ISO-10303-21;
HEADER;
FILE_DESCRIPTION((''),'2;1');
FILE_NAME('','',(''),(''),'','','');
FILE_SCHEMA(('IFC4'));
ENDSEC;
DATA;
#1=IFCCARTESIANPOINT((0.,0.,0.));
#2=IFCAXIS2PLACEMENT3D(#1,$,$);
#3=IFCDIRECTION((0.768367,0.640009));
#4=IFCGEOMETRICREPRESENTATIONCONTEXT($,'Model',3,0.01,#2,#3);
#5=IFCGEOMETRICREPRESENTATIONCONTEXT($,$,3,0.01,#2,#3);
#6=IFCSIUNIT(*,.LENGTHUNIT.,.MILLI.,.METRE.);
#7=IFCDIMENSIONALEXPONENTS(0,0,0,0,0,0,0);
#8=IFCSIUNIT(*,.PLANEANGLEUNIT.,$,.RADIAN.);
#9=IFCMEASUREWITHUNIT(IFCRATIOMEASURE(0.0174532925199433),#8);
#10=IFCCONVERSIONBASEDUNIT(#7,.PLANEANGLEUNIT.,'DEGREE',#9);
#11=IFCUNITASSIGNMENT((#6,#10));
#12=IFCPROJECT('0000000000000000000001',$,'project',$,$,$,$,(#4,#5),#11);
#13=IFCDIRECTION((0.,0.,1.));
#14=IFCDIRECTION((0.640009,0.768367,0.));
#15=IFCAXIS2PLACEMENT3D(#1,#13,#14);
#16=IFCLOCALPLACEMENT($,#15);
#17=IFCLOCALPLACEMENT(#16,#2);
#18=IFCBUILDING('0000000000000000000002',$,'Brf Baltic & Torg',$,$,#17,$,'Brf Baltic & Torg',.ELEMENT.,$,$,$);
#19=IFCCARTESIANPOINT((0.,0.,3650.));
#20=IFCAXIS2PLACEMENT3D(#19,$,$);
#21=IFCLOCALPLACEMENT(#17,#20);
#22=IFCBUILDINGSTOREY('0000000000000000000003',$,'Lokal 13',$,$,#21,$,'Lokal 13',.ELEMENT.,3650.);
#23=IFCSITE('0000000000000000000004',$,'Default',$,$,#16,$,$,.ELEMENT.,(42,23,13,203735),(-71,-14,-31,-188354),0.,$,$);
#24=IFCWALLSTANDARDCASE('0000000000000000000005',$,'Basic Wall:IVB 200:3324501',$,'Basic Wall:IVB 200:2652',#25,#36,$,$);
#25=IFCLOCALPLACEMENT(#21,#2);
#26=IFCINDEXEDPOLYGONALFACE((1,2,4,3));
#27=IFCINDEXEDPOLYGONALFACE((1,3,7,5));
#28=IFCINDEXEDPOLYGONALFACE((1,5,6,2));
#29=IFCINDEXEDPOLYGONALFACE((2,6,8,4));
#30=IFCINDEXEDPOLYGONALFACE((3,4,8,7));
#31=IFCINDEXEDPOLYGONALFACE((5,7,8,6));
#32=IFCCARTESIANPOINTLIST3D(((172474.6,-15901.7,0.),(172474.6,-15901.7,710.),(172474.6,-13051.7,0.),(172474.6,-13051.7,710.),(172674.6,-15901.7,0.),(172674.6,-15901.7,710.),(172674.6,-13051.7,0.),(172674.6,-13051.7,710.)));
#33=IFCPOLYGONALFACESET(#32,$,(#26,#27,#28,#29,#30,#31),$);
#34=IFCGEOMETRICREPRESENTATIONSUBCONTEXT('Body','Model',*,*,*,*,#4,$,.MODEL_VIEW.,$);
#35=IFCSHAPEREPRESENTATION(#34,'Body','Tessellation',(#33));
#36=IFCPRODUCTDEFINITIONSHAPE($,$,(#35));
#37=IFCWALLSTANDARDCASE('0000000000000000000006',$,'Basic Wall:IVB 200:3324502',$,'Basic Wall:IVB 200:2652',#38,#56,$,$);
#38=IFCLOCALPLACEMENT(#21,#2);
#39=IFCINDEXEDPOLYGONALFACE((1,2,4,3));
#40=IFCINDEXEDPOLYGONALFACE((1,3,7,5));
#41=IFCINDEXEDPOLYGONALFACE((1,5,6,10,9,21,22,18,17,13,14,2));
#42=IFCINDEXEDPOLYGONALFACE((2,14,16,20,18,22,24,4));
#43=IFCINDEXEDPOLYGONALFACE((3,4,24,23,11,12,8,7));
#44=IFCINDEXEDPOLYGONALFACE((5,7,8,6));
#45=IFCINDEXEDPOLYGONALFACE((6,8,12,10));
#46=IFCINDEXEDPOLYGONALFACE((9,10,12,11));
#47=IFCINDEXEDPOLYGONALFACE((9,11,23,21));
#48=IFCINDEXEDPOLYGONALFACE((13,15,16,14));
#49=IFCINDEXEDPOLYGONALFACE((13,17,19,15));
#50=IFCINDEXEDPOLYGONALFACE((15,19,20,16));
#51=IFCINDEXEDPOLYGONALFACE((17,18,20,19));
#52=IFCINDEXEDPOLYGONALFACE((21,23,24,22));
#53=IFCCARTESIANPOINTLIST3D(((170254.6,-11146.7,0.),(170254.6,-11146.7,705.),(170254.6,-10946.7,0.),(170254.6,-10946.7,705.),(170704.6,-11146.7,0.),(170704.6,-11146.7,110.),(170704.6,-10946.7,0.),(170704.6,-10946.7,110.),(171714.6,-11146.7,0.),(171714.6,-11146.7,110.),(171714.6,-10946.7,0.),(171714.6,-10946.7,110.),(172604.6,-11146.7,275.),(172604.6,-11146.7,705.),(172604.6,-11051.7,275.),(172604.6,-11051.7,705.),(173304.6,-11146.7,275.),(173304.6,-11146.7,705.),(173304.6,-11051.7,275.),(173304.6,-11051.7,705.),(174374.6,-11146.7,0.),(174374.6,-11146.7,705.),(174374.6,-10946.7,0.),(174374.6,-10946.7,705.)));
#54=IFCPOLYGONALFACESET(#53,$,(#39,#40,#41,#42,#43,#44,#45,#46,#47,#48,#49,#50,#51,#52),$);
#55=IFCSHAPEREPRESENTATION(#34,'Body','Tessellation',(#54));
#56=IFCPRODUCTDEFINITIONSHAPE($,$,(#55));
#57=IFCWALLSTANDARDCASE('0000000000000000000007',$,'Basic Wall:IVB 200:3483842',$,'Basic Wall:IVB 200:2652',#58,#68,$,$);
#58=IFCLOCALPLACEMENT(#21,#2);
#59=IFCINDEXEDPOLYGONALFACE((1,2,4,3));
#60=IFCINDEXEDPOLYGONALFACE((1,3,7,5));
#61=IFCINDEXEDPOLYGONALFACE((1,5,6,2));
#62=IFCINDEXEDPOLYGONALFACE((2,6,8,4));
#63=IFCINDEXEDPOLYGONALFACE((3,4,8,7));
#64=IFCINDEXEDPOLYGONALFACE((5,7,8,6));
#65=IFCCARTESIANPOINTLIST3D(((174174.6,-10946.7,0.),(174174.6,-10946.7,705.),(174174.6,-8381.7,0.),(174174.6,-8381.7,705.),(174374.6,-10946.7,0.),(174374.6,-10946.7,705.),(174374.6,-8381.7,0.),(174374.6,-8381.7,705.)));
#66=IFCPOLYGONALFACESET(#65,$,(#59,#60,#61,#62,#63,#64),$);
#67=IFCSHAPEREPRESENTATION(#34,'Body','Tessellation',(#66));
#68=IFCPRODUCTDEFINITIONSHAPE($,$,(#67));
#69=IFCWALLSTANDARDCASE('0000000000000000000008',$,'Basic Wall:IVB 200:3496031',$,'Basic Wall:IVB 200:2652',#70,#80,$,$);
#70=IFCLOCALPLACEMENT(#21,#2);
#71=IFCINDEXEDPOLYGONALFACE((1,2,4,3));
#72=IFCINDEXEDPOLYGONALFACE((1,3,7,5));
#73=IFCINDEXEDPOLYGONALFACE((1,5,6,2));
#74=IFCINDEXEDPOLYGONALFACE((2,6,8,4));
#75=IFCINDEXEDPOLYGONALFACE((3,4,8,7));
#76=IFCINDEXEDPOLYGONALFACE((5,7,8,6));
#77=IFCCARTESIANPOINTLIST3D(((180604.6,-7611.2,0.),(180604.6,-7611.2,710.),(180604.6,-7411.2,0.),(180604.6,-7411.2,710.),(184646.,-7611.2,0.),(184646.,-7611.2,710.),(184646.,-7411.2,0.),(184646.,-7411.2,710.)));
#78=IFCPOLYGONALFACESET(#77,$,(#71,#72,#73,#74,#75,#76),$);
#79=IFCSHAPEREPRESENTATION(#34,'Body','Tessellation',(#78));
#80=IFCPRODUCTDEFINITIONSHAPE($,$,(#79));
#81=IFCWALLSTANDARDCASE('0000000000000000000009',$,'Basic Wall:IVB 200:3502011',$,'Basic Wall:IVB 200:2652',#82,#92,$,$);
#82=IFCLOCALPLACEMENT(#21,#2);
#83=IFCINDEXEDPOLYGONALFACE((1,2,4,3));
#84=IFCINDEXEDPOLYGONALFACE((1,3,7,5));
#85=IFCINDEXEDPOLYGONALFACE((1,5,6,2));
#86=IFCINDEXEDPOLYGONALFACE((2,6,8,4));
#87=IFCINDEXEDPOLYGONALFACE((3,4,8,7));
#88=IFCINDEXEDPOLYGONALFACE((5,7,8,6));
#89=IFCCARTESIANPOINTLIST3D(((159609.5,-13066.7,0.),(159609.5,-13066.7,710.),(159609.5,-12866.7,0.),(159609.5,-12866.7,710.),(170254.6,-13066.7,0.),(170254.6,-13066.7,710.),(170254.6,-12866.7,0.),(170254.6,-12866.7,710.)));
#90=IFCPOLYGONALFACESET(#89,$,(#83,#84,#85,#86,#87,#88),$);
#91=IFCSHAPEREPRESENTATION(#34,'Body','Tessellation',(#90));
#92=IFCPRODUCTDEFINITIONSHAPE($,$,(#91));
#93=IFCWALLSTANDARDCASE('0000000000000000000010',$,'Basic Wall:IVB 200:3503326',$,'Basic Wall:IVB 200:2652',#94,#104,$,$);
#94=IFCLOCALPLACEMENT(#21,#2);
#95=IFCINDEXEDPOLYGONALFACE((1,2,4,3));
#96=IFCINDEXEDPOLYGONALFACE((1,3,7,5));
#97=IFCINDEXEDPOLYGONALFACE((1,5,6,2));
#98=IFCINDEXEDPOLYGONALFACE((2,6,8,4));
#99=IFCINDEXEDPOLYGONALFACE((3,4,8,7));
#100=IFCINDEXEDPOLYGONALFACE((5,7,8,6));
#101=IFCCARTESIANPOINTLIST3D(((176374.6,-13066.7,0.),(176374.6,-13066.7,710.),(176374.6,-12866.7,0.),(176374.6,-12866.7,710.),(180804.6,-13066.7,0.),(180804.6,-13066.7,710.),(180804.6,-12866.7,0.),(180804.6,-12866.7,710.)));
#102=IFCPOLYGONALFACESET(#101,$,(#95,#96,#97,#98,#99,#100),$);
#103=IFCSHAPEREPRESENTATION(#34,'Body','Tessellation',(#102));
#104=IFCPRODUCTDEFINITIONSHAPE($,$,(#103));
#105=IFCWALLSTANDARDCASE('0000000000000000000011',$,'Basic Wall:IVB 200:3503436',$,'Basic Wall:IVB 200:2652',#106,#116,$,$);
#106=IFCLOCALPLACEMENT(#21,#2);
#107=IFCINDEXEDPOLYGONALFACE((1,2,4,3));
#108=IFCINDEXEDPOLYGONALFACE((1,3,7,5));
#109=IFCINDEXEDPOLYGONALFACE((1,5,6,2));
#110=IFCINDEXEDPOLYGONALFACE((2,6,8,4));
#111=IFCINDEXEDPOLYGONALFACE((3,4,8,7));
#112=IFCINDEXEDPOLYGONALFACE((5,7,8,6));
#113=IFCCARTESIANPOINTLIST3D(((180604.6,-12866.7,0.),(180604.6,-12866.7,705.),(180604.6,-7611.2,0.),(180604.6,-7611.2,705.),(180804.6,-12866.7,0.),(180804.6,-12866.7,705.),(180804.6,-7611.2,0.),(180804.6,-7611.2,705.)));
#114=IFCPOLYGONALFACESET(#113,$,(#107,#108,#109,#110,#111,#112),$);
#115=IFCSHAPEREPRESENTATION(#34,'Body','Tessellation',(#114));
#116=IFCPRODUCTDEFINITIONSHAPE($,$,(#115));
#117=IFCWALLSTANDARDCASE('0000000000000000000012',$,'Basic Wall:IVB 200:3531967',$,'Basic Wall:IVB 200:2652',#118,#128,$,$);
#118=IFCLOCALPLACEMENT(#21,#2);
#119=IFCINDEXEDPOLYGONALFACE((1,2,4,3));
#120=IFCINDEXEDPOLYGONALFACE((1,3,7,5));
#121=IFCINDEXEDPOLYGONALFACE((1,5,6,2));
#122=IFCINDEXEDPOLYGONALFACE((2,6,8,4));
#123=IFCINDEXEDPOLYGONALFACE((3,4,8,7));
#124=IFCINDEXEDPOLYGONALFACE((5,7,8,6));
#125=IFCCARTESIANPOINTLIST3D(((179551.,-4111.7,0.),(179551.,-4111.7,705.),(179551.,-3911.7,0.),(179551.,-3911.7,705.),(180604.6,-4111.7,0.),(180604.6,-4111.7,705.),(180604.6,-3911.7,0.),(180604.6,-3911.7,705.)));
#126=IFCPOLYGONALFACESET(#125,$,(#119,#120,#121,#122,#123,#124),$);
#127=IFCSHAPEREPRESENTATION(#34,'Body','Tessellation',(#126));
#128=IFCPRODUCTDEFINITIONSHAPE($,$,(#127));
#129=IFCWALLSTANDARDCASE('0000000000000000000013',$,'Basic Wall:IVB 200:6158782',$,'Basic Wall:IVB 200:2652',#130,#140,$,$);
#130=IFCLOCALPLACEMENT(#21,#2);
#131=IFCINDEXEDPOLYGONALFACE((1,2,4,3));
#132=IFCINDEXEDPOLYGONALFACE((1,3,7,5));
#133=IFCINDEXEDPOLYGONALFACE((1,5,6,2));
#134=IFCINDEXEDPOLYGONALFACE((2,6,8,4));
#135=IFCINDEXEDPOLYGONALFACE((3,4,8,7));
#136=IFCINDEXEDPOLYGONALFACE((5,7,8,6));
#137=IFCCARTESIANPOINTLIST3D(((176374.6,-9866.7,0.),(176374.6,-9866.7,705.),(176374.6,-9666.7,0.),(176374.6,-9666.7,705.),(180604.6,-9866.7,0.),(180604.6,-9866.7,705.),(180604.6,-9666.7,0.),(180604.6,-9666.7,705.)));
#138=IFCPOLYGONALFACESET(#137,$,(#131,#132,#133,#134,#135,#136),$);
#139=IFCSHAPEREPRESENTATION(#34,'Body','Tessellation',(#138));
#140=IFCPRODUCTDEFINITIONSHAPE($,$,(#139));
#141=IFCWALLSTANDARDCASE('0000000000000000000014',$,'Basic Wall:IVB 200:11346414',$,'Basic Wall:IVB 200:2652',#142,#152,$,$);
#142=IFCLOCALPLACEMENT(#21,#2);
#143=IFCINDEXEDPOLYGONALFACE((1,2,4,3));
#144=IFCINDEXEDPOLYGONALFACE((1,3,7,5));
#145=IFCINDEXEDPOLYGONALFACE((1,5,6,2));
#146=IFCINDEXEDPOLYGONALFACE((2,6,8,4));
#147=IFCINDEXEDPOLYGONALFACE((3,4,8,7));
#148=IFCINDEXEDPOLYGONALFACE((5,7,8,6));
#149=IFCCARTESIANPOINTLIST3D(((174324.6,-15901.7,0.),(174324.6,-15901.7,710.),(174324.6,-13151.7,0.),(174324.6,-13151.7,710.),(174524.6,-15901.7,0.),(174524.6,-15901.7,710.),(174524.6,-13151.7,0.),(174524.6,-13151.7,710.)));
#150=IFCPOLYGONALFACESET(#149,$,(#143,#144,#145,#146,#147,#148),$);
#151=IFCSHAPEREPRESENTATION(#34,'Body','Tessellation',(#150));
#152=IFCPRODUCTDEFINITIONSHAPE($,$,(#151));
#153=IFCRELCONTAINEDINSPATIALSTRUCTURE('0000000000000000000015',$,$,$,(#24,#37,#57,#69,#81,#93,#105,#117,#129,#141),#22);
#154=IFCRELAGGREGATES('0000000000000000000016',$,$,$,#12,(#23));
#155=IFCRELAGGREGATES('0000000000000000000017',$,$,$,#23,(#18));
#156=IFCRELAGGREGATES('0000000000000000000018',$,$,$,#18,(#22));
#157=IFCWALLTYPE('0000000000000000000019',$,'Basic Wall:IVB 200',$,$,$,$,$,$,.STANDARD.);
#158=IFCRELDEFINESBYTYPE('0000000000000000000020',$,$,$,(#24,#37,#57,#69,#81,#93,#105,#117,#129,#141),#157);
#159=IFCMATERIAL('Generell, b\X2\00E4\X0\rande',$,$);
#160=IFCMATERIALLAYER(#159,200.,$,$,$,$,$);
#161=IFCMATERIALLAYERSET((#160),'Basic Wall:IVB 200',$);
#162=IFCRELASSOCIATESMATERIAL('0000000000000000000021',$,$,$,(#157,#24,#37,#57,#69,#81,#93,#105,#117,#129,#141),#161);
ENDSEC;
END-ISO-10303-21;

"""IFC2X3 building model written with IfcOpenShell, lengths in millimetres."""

from ifc_helpers import new_model, entity, si_unit, converted_unit, direction, frame, frame_2d, origin, place, context, subcontext, project, spatial, polyline, rectangle, extrude, clip, halfspace, bounded_halfspace, material, layer, layer_set, layer_usage, type_object, element, save


model = new_model("IFC2X3")

# Units and contexts
model_context = context("Model", 3, precision=0.01, world=origin(), true_north=direction((0.768367, 0.640009)))
context_of_model = context(None, 3, precision=0.01, world=origin(), true_north=direction((0.768367, 0.640009)))
body_context = subcontext(model_context, "Body", "Model", "MODEL_VIEW")
ifc_project = project(units=[si_unit("LENGTHUNIT", "METRE", prefix="MILLI"), converted_unit("PLANEANGLEUNIT", "DEGREE", entity("IfcRatioMeasure", 0.0174532925199433), si_unit("PLANEANGLEUNIT", "RADIAN"), dimensions=[0, 0, 0, 0, 0, 0, 0])], contexts=[model_context, context_of_model])

# Site, building, storey
site_placement = place(None, frame((0.0, 0.0, 0.0), z_axis=(0.0, 0.0, 1.0), x_axis=(0.640009, 0.768367, 0.0)))
site = spatial("IfcSite", under=ifc_project, at=site_placement, Name="Default", CompositionType="ELEMENT", RefLatitude=(42, 23, 13, 203735), RefLongitude=(-71, -14, -31, -188354), RefElevation=0.0)
building_placement = place(site_placement, origin())
building = spatial("IfcBuilding", under=site, at=building_placement, Name="Brf Baltic & Torg", LongName="Brf Baltic & Torg", CompositionType="ELEMENT")
storey_placement = place(building_placement, frame((0.0, 0.0, 3650.0)))
storey = spatial("IfcBuildingStorey", under=building, at=storey_placement, Name="Lokal 13", LongName="Lokal 13", CompositionType="ELEMENT", Elevation=3650.0)

# Shared definitions
ifc_material = material(Name="Generell, bärande")
ifc_layer_1 = layer(ifc_material, 200.0)
ifc_layer_set_1 = layer_set([ifc_layer_1], Name="Basic Wall:IVB 200")
wall_type_1 = type_object("IfcWallType", Name="Basic Wall:IVB 200", PredefinedType="STANDARD", material=ifc_layer_set_1)

# Wall
ifc_layer_usage_1 = layer_usage(ifc_layer_set_1, "AXIS2", "POSITIVE", -100.0)
wall_1_placement = place(storey_placement, frame((172574.6, -15901.7, 0.0), z_axis=(0.0, 0.0, 1.0), x_axis=(0.0, 1.0, 0.0)))
element("IfcWallStandardCase", 1, at=wall_1_placement, inside=storey, type_object=wall_type_1, material=ifc_layer_usage_1, Name="Basic Wall:IVB 200:3324501", ObjectType="Basic Wall:IVB 200:2652", context=body_context, shape_type="Clipping", body=[
    clip(extrude(rectangle(XDim=2850.0, YDim=200.0, at=frame_2d((1425.0, 0.0), x_axis=(-1.0, 0.0))), origin(), (0.0, 0.0, 1.0), 710.0), halfspace(frame((0.0, 0.0, -2000.0)), True)),
])

# Wall, openings
ifc_layer_usage_2 = layer_usage(ifc_layer_set_1, "AXIS2", "POSITIVE", -100.0)
wall_2_placement = place(storey_placement, frame((174374.6, -11046.7, 0.0), z_axis=(0.0, 0.0, 1.0), x_axis=(-1.0, 0.0, 0.0)))
wall_2 = element("IfcWallStandardCase", 2, at=wall_2_placement, inside=storey, type_object=wall_type_1, material=ifc_layer_usage_2, Name="Basic Wall:IVB 200:3324502", ObjectType="Basic Wall:IVB 200:2652", context=body_context, shape_type="Clipping", body=[
    clip(clip(extrude(rectangle(XDim=4120.0, YDim=200.0, at=frame_2d((2060.0, 0.0), x_axis=(-1.0, 0.0))), origin(), (0.0, 0.0, 1.0), 705.0), bounded_halfspace(frame((0.0, 100.0, 705.0), z_axis=(0.0, 0.0, -1.0), x_axis=(0.0, -1.0, 0.0)), True, frame((0.0, 100.0, 705.0)), polyline([(0.0, 0.0), (0.0, -200.0), (200.0, -200.0), (4120.0, -200.0), (4120.0, 0.0), (3920.0, 0.0), (1770.0, 0.0), (1770.0, -95.0), (1070.0, -95.0), (1070.0, 0.0), (0.0, 0.0)]))), halfspace(frame((0.0, 0.0, -2000.0)), True)),
])
opening_1_placement = place(wall_2_placement, origin())
element("IfcOpeningElement", 3, at=opening_1_placement, cuts=wall_2, ObjectType="Recess", context=body_context, shape_type="SweptSolid", body=[
    extrude(rectangle(XDim=430.0, YDim=700.0, at=frame_2d((0.0, 0.0), x_axis=(1.0, 0.0))), frame((1420.0, 5.0, 490.0), z_axis=(0.0, 1.0, 0.0), x_axis=(0.0, 0.0, -1.0)), (0.0, 0.0, 1.0), 95.0),
])
opening_2_placement = place(wall_2_placement, frame((174374.6, -11046.7, -2000.0), z_axis=(0.0, 0.0, 1.0), x_axis=(-1.0, 0.0, 0.0)))
element("IfcOpeningElement", 4, at=opening_2_placement, cuts=wall_2, ObjectType="Opening", context=body_context, shape_type="SweptSolid", body=[
    extrude(rectangle(XDim=2110.0, YDim=1010.0, at=frame_2d((0.0, 0.0), x_axis=(0.0, 1.0))), frame((171209.6, -9422.7, 1055.0), z_axis=(0.0, -1.0, 0.0), x_axis=(1.0, 0.0, 0.0)), (0.0, 0.0, 1.0), 3048.0),
])

# Walls
ifc_layer_usage_3 = layer_usage(ifc_layer_set_1, "AXIS2", "POSITIVE", -100.0)
wall_3_placement = place(storey_placement, frame((174274.6, -8381.7, 0.0), z_axis=(0.0, 0.0, 1.0), x_axis=(0.0, -1.0, 0.0)))
element("IfcWallStandardCase", 5, at=wall_3_placement, inside=storey, type_object=wall_type_1, material=ifc_layer_usage_3, Name="Basic Wall:IVB 200:3483842", ObjectType="Basic Wall:IVB 200:2652", context=body_context, shape_type="Clipping", body=[
    clip(clip(extrude(rectangle(XDim=2565.0, YDim=200.0, at=frame_2d((1282.5, 0.0), x_axis=(-1.0, 0.0))), origin(), (0.0, 0.0, 1.0), 705.0), bounded_halfspace(frame((0.0, -100.0, 705.0), z_axis=(0.0, 0.0, -1.0), x_axis=(-1.0, 0.0, 0.0)), True, frame((0.0, -100.0, 705.0)), polyline([(0.0, 0.0), (2565.0, 0.0), (2565.0, 200.0), (0.0, 200.0), (0.0, 0.0)]))), halfspace(frame((0.0, 0.0, -2000.0)), True)),
])
ifc_layer_usage_4 = layer_usage(ifc_layer_set_1, "AXIS2", "NEGATIVE", 100.0)
wall_4_placement = place(storey_placement, frame((180604.6, -7511.2, 0.0)))
element("IfcWallStandardCase", 6, at=wall_4_placement, inside=storey, type_object=wall_type_1, material=ifc_layer_usage_4, Name="Basic Wall:IVB 200:3496031", ObjectType="Basic Wall:IVB 200:2652", context=body_context, shape_type="Clipping", body=[
    clip(extrude(rectangle(XDim=4041.4, YDim=200.0, at=frame_2d((2020.7, 0.0), x_axis=(-1.0, 0.0))), origin(), (0.0, 0.0, 1.0), 710.0), halfspace(frame((0.0, 0.0, -2000.0)), True)),
])
ifc_layer_usage_5 = layer_usage(ifc_layer_set_1, "AXIS2", "NEGATIVE", 100.0)
wall_5_placement = place(storey_placement, frame((170254.6, -12966.7, 0.0), z_axis=(0.0, 0.0, 1.0), x_axis=(-1.0, 0.0, 0.0)))
element("IfcWallStandardCase", 7, at=wall_5_placement, inside=storey, type_object=wall_type_1, material=ifc_layer_usage_5, Name="Basic Wall:IVB 200:3502011", ObjectType="Basic Wall:IVB 200:2652", context=body_context, shape_type="Clipping", body=[
    clip(extrude(rectangle(XDim=10645.0, YDim=200.0, at=frame_2d((5322.5, 0.0), x_axis=(-1.0, 0.0))), origin(), (0.0, 0.0, 1.0), 710.0), halfspace(frame((0.0, 0.0, -2000.0)), True)),
])
ifc_layer_usage_6 = layer_usage(ifc_layer_set_1, "AXIS2", "NEGATIVE", 100.0)
wall_6_placement = place(storey_placement, frame((180804.6, -12966.7, 0.0), z_axis=(0.0, 0.0, 1.0), x_axis=(-1.0, 0.0, 0.0)))
element("IfcWallStandardCase", 8, at=wall_6_placement, inside=storey, type_object=wall_type_1, material=ifc_layer_usage_6, Name="Basic Wall:IVB 200:3503326", ObjectType="Basic Wall:IVB 200:2652", context=body_context, shape_type="Clipping", body=[
    clip(extrude(rectangle(XDim=4430.0, YDim=200.0, at=frame_2d((2215.0, 0.0), x_axis=(-1.0, 0.0))), origin(), (0.0, 0.0, 1.0), 710.0), halfspace(frame((0.0, 0.0, -2000.0)), True)),
])
ifc_layer_usage_7 = layer_usage(ifc_layer_set_1, "AXIS2", "NEGATIVE", 100.0)
wall_7_placement = place(storey_placement, frame((180704.6, -7611.2, 0.0), z_axis=(0.0, 0.0, 1.0), x_axis=(0.0, -1.0, 0.0)))
element("IfcWallStandardCase", 9, at=wall_7_placement, inside=storey, type_object=wall_type_1, material=ifc_layer_usage_7, Name="Basic Wall:IVB 200:3503436", ObjectType="Basic Wall:IVB 200:2652", context=body_context, shape_type="Clipping", body=[
    clip(extrude(rectangle(XDim=5255.5, YDim=200.0, at=frame_2d((2627.7, 0.0), x_axis=(-1.0, 0.0))), origin(), (0.0, 0.0, 1.0), 705.0), halfspace(frame((0.0, 0.0, -2000.0)), True)),
])

# Walls
ifc_layer_usage_8 = layer_usage(ifc_layer_set_1, "AXIS2", "NEGATIVE", 100.0)
wall_8_placement = place(storey_placement, frame((179551.0, -4011.7, 0.0)))
element("IfcWallStandardCase", 10, at=wall_8_placement, inside=storey, type_object=wall_type_1, material=ifc_layer_usage_8, Name="Basic Wall:IVB 200:3531967", ObjectType="Basic Wall:IVB 200:2652", context=body_context, shape_type="Clipping", body=[
    clip(clip(extrude(rectangle(XDim=1053.6, YDim=200.0, at=frame_2d((526.8, 0.0), x_axis=(-1.0, 0.0))), origin(), (0.0, 0.0, 1.0), 705.0), bounded_halfspace(frame((0.0, -100.0, 705.0), z_axis=(0.0, 0.0, -1.0), x_axis=(0.0, 1.0, 0.0)), True, frame((0.0, -100.0, 705.0)), polyline([(0.0, 0.0), (1053.6, 0.0), (1053.6, 200.0), (0.0, 200.0), (0.0, 0.0)]))), halfspace(frame((0.0, 0.0, -2000.0)), True)),
])
ifc_layer_usage_9 = layer_usage(ifc_layer_set_1, "AXIS2", "NEGATIVE", 100.0)
wall_9_placement = place(storey_placement, frame((180604.6, -9766.7, 0.0), z_axis=(0.0, 0.0, 1.0), x_axis=(-1.0, 0.0, 0.0)))
element("IfcWallStandardCase", 11, at=wall_9_placement, inside=storey, type_object=wall_type_1, material=ifc_layer_usage_9, Name="Basic Wall:IVB 200:6158782", ObjectType="Basic Wall:IVB 200:2652", context=body_context, shape_type="Clipping", body=[
    clip(clip(extrude(rectangle(XDim=4230.0, YDim=200.0, at=frame_2d((2115.0, 0.0), x_axis=(-1.0, 0.0))), origin(), (0.0, 0.0, 1.0), 705.0), bounded_halfspace(frame((0.0, -100.0, 705.0), z_axis=(0.0, 0.0, -1.0), x_axis=(0.0, -1.0, 0.0)), True, frame((0.0, -100.0, 705.0)), polyline([(0.0, 0.0), (4230.0, 0.0), (4230.0, 200.0), (0.0, 200.0), (0.0, 0.0)]))), halfspace(frame((0.0, 0.0, -2000.0)), True)),
])

# Wall
ifc_layer_usage_10 = layer_usage(ifc_layer_set_1, "AXIS2", "POSITIVE", -100.0)
wall_10_placement = place(storey_placement, frame((174424.6, -15901.7, 0.0), z_axis=(0.0, 0.0, 1.0), x_axis=(0.0, 1.0, 0.0)))
element("IfcWallStandardCase", 12, at=wall_10_placement, inside=storey, type_object=wall_type_1, material=ifc_layer_usage_10, Name="Basic Wall:IVB 200:11346414", ObjectType="Basic Wall:IVB 200:2652", context=body_context, shape_type="Clipping", body=[
    clip(extrude(rectangle(XDim=2750.0, YDim=200.0, at=frame_2d((1375.0, 0.0), x_axis=(-1.0, 0.0))), origin(), (0.0, 0.0, 1.0), 710.0), halfspace(frame((0.0, 0.0, -2000.0)), True)),
])

save(model, "model.ifc")
